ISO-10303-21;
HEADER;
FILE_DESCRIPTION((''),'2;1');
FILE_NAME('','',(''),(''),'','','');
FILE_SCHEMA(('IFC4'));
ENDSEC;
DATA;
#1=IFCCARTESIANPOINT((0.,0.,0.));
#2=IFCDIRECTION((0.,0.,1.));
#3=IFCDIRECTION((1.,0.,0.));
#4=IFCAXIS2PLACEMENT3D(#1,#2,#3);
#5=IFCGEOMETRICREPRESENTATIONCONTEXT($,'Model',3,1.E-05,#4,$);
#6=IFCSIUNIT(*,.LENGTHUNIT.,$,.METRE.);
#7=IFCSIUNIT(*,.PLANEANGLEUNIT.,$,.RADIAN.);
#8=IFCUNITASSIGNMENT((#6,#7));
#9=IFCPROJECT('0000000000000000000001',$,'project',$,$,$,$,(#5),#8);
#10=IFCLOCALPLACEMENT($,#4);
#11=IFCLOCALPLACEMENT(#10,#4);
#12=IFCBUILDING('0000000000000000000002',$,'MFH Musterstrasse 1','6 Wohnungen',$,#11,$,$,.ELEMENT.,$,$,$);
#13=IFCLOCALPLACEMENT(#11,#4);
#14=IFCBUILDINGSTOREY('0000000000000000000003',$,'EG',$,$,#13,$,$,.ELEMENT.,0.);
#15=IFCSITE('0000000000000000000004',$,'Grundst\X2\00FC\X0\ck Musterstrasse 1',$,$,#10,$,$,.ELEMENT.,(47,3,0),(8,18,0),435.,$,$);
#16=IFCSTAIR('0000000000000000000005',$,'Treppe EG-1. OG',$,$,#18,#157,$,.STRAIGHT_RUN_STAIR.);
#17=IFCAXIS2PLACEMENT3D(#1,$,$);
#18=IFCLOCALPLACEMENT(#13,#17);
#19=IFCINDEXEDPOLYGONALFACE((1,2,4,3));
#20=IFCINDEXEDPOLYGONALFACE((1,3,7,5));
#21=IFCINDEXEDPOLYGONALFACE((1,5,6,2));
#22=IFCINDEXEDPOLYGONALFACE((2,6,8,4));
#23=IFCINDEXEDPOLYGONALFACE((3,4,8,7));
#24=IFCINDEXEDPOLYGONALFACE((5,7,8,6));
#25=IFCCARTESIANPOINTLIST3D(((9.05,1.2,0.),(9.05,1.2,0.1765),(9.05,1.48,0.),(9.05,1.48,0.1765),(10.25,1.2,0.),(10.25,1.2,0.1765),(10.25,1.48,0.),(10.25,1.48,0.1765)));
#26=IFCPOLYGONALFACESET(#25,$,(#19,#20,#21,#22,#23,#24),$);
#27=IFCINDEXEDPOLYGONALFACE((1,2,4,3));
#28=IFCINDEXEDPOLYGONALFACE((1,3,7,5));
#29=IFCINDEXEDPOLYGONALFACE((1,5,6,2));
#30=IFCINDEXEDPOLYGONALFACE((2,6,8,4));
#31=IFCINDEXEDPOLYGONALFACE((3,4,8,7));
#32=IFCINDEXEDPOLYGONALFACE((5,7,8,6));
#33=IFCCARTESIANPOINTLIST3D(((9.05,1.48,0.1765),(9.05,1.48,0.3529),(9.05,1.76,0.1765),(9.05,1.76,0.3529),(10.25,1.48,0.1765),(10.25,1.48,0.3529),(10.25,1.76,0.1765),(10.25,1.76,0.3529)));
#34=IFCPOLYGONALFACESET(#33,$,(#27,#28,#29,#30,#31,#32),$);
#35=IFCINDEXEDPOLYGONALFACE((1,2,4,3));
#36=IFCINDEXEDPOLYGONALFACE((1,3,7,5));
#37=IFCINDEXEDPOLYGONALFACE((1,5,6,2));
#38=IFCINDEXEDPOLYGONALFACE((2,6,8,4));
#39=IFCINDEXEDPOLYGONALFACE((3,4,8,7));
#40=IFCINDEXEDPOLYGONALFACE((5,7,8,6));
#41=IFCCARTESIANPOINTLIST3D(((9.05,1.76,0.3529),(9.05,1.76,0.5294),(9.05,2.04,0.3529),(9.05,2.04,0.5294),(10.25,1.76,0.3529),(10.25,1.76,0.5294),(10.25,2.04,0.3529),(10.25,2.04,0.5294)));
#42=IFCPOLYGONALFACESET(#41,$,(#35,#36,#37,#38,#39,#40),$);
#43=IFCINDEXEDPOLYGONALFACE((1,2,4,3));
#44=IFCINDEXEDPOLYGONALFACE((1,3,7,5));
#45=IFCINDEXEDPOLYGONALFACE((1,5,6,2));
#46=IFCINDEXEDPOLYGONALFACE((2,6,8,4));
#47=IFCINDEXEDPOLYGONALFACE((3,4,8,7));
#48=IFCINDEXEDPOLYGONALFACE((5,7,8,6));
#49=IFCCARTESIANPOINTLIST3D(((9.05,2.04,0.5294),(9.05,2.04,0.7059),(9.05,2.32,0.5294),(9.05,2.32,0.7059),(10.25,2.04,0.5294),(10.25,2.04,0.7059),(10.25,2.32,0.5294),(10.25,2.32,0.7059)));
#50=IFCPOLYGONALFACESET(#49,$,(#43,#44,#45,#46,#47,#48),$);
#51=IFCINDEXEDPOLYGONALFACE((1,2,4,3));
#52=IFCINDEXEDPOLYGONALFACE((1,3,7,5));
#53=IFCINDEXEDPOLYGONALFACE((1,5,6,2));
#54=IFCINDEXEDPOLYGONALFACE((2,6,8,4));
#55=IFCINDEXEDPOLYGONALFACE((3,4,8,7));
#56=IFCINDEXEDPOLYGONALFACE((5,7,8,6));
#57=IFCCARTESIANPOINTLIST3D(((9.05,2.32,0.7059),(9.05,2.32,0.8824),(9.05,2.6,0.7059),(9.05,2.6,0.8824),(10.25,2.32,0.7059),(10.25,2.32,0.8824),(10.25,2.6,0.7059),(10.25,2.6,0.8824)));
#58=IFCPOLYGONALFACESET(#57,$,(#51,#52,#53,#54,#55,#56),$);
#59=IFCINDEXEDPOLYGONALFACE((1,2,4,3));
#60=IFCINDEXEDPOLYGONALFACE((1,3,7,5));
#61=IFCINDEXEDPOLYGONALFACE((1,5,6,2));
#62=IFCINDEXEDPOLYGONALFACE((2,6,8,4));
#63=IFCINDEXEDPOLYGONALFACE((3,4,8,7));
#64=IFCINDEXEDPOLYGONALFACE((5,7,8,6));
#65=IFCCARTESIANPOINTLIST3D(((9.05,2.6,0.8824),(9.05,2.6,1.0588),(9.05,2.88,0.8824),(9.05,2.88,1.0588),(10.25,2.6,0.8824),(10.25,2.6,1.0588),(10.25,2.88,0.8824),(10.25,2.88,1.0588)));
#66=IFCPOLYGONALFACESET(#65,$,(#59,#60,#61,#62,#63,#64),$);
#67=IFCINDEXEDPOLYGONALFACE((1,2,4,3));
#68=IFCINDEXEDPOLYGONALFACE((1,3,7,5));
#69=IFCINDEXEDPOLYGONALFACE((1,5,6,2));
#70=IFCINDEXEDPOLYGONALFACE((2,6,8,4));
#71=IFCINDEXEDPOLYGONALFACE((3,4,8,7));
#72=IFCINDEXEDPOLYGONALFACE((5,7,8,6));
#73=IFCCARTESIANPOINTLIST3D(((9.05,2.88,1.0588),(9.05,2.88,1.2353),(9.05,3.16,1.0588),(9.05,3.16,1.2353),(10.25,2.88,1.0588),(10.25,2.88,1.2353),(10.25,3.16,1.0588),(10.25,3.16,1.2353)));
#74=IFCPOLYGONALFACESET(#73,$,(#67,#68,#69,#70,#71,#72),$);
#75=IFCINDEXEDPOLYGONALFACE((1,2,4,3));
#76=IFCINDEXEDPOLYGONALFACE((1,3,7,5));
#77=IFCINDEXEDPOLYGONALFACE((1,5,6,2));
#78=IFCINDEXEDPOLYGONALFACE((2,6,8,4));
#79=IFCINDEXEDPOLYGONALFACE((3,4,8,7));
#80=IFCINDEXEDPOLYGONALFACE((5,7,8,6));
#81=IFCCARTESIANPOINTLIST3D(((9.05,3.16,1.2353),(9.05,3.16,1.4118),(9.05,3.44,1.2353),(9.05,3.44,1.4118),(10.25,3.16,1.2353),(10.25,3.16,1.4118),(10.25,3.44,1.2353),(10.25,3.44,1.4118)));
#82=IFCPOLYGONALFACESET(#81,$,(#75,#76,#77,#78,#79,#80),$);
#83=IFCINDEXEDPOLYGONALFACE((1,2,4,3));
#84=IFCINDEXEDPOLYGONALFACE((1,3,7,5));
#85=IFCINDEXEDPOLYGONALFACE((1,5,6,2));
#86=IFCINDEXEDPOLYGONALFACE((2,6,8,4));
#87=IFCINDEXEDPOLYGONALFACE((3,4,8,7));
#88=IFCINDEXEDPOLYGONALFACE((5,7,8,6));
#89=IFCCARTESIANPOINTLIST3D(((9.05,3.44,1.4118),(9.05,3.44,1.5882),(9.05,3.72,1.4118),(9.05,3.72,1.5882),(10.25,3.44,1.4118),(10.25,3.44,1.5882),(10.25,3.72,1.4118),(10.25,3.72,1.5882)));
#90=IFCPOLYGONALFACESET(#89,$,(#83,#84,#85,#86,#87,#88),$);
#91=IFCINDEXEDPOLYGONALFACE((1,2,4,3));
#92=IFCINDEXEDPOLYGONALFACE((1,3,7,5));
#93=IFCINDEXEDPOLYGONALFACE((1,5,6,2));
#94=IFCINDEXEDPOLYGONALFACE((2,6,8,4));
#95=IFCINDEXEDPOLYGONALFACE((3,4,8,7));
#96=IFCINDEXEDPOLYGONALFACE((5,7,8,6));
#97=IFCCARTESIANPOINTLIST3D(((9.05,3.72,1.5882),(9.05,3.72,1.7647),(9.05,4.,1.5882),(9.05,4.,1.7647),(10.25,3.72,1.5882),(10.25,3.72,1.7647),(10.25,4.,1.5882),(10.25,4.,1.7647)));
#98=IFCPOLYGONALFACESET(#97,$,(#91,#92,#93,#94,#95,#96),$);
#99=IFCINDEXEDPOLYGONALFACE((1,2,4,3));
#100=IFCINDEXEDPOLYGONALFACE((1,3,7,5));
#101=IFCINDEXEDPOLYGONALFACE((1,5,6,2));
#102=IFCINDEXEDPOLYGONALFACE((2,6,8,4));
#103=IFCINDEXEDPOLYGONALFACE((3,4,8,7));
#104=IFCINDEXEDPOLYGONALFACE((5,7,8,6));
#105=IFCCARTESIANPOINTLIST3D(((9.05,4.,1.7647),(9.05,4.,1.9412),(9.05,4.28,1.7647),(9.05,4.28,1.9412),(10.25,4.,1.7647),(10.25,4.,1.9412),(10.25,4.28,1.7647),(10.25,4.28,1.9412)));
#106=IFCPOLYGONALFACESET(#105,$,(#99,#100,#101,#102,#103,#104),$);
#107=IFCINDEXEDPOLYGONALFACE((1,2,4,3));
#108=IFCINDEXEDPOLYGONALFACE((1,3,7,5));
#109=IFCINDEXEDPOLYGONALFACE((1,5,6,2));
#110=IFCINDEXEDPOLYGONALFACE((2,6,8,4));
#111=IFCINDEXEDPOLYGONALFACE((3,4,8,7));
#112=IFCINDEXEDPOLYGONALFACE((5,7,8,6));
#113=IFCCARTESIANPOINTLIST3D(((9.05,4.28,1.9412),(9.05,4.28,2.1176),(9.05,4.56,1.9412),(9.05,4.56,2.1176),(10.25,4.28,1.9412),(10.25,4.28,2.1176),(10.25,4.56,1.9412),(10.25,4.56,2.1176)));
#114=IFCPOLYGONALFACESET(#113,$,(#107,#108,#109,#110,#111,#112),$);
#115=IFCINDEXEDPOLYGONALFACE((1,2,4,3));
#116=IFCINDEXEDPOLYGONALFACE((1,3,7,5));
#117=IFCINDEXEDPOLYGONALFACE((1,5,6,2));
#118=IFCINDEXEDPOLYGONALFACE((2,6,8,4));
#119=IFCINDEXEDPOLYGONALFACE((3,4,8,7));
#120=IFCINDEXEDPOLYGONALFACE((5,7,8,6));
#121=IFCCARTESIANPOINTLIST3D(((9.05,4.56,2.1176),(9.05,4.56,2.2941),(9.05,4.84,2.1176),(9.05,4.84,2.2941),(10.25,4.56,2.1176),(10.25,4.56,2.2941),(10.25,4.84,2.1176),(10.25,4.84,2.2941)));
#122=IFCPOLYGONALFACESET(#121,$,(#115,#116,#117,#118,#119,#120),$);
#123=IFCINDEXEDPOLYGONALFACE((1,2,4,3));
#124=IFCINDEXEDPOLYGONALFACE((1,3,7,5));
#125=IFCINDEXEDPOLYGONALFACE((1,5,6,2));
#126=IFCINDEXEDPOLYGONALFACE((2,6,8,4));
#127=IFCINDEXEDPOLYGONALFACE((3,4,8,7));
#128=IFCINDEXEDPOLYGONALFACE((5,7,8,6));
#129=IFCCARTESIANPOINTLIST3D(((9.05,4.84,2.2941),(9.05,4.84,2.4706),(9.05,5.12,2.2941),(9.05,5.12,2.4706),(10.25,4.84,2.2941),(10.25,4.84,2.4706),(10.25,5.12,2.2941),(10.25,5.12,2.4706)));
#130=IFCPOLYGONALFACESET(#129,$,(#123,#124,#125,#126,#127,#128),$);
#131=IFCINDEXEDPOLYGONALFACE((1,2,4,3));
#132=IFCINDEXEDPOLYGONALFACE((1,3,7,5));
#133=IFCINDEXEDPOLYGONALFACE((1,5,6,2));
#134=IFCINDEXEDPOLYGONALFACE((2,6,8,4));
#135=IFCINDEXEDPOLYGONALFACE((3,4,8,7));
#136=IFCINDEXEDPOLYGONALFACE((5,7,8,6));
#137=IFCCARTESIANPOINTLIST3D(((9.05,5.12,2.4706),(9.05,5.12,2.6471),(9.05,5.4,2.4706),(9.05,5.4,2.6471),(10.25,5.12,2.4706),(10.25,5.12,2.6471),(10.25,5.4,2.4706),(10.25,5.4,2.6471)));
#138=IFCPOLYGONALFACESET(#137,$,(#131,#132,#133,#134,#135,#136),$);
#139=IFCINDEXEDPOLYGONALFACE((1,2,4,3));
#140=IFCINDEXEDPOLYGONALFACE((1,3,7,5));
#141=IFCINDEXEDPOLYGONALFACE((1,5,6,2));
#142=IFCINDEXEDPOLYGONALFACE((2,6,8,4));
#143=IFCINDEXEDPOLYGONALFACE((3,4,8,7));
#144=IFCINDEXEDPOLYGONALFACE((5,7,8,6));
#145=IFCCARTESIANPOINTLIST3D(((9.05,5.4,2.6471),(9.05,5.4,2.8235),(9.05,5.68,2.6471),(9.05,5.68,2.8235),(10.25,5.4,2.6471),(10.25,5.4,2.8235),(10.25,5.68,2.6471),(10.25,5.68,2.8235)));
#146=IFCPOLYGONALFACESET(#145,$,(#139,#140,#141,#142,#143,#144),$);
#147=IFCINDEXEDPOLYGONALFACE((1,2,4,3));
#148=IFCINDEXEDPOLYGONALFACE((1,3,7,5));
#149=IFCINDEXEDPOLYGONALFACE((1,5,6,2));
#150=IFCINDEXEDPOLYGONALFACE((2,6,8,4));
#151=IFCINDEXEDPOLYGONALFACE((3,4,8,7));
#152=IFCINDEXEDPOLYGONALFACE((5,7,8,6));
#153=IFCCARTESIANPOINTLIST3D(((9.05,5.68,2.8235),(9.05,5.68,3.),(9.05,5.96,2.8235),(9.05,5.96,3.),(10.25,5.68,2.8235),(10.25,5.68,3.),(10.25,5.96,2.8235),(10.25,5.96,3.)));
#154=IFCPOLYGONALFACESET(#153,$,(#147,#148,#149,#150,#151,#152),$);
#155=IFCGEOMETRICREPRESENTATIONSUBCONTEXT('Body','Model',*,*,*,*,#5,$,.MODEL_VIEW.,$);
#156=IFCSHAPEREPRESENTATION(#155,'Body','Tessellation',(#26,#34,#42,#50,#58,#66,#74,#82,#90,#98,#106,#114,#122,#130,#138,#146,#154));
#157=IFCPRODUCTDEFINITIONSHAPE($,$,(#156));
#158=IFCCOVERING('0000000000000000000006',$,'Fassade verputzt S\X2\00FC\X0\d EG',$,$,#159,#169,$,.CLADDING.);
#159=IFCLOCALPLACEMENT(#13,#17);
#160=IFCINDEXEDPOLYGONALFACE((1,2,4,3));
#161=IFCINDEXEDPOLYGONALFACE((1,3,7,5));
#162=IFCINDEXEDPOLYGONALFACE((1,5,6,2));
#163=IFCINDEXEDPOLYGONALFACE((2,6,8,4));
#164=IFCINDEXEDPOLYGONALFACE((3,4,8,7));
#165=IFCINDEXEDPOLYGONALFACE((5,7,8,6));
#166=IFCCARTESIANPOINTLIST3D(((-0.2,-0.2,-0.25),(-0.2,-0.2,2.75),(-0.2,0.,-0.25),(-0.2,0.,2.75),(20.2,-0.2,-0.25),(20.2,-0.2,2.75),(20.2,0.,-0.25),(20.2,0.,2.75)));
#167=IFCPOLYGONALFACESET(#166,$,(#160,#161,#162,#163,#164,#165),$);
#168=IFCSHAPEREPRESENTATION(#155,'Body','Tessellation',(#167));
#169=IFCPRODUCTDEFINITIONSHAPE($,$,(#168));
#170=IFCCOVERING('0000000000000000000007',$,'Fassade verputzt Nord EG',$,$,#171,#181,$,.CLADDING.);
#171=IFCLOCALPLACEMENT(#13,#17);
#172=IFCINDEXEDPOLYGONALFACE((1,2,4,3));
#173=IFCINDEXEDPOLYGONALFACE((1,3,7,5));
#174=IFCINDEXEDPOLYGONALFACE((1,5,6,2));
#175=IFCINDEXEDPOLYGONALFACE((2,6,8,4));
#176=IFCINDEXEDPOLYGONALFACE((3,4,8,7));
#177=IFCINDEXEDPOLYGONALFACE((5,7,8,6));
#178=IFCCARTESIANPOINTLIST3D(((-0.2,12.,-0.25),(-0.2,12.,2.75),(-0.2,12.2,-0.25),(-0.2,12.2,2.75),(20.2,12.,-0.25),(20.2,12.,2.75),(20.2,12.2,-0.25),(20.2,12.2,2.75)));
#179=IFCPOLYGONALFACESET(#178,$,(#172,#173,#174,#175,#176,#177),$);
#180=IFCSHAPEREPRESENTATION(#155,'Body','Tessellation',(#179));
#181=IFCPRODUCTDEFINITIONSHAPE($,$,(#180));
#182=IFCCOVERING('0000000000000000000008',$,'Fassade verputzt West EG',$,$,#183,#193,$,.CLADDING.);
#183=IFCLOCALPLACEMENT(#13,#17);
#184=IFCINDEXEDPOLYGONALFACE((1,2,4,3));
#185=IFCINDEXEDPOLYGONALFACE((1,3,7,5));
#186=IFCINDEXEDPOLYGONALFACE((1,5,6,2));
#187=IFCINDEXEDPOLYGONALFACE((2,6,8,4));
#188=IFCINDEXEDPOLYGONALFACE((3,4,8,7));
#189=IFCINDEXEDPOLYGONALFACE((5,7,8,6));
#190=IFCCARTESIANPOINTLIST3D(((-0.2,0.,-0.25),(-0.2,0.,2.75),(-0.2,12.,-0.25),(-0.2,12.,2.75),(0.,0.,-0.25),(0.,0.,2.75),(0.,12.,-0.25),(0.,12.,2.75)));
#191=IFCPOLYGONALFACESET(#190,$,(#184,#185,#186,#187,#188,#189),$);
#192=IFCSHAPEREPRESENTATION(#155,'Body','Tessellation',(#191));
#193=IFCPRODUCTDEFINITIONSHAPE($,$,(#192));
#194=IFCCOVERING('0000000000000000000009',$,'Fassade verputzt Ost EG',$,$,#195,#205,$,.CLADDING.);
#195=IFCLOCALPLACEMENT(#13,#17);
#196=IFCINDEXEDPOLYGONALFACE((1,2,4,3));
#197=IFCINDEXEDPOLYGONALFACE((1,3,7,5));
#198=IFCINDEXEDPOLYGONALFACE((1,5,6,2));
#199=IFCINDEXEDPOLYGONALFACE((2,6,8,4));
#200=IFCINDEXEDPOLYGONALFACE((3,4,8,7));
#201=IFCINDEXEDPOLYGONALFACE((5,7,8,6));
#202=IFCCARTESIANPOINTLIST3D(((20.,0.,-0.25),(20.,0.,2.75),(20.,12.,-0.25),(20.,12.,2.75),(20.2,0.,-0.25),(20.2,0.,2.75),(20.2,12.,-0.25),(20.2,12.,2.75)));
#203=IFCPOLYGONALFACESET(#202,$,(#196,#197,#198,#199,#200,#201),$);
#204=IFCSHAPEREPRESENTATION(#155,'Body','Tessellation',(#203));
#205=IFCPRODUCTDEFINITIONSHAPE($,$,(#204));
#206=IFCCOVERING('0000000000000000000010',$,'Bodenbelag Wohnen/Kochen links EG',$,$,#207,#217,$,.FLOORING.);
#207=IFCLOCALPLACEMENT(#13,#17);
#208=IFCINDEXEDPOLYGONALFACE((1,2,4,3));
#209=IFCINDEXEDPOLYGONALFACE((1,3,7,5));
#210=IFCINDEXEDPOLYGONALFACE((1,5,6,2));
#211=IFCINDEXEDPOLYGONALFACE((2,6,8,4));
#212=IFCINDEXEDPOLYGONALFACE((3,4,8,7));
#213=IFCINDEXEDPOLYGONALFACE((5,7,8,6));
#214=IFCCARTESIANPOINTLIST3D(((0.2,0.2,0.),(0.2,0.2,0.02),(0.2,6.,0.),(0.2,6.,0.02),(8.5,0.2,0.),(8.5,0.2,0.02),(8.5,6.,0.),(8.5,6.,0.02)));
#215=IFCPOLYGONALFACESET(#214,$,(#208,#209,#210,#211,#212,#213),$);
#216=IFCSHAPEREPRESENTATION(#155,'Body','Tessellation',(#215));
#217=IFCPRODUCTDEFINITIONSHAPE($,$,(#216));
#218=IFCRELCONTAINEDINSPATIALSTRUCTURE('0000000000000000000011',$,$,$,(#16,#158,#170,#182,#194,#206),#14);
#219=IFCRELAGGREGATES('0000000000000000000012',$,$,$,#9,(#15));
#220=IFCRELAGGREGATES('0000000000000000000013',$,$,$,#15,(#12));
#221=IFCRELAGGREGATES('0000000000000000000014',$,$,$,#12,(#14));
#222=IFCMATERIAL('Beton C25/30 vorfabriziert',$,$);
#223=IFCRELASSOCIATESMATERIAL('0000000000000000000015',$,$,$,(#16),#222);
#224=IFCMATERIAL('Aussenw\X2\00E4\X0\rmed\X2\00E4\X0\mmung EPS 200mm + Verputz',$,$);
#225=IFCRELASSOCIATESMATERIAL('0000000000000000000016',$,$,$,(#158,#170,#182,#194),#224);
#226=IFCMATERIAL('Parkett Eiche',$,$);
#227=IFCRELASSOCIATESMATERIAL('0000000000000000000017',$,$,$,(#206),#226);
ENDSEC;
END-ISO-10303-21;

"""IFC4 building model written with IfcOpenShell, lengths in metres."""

from ifc_helpers import new_model, si_unit, frame, frame_2d, origin_with_axes, place, context, subcontext, project, spatial, rectangle, extrude, material, element, save


model = new_model("IFC4")

# Units and contexts
model_context = context("Model", 3, precision=1e-05, world=origin_with_axes())
body_context = subcontext(model_context, "Body", "Model", "MODEL_VIEW")
ifc_project = project(units=[si_unit("LENGTHUNIT", "METRE"), si_unit("PLANEANGLEUNIT", "RADIAN")], contexts=[model_context])

# Site, building, storey
site_placement = place(None, origin_with_axes())
site = spatial("IfcSite", under=ifc_project, at=site_placement, Name="Grundstück Musterstrasse 1", CompositionType="ELEMENT", RefLatitude=(47, 3, 0), RefLongitude=(8, 18, 0), RefElevation=435.0)
building_placement = place(site_placement, origin_with_axes())
building = spatial("IfcBuilding", under=site, at=building_placement, Name="MFH Musterstrasse 1", Description="6 Wohnungen", CompositionType="ELEMENT")
storey_placement = place(building_placement, origin_with_axes())
storey = spatial("IfcBuildingStorey", under=building, at=storey_placement, Name="EG", CompositionType="ELEMENT", Elevation=0.0)

# Stair
ifc_material_1 = material(Name="Beton C25/30 vorfabriziert")
stair_placement = place(storey_placement, origin_with_axes())
element("IfcStair", 1, at=stair_placement, inside=storey, material=ifc_material_1, Name="Treppe EG-1. OG", PredefinedType="STRAIGHT_RUN_STAIR", context=body_context, shape_type="SweptSolid", body=[
    extrude(rectangle(XDim=1.2, YDim=0.28, at=frame_2d((0.6, 0.14), x_axis=(1.0, 0.0))), frame((9.05, 1.2, 0.0), z_axis=(0.0, 0.0, 1.0), x_axis=(1.0, 0.0, 0.0)), (0.0, 0.0, 1.0), 0.1765),
    extrude(rectangle(XDim=1.2, YDim=0.28, at=frame_2d((0.6, 0.14), x_axis=(1.0, 0.0))), frame((9.05, 1.48, 0.1765), z_axis=(0.0, 0.0, 1.0), x_axis=(1.0, 0.0, 0.0)), (0.0, 0.0, 1.0), 0.1765),
    extrude(rectangle(XDim=1.2, YDim=0.28, at=frame_2d((0.6, 0.14), x_axis=(1.0, 0.0))), frame((9.05, 1.76, 0.3529), z_axis=(0.0, 0.0, 1.0), x_axis=(1.0, 0.0, 0.0)), (0.0, 0.0, 1.0), 0.1765),
    extrude(rectangle(XDim=1.2, YDim=0.28, at=frame_2d((0.6, 0.14), x_axis=(1.0, 0.0))), frame((9.05, 2.04, 0.5294), z_axis=(0.0, 0.0, 1.0), x_axis=(1.0, 0.0, 0.0)), (0.0, 0.0, 1.0), 0.1765),
    extrude(rectangle(XDim=1.2, YDim=0.28, at=frame_2d((0.6, 0.14), x_axis=(1.0, 0.0))), frame((9.05, 2.32, 0.7059), z_axis=(0.0, 0.0, 1.0), x_axis=(1.0, 0.0, 0.0)), (0.0, 0.0, 1.0), 0.1765),
    extrude(rectangle(XDim=1.2, YDim=0.28, at=frame_2d((0.6, 0.14), x_axis=(1.0, 0.0))), frame((9.05, 2.6, 0.8824), z_axis=(0.0, 0.0, 1.0), x_axis=(1.0, 0.0, 0.0)), (0.0, 0.0, 1.0), 0.1765),
    extrude(rectangle(XDim=1.2, YDim=0.28, at=frame_2d((0.6, 0.14), x_axis=(1.0, 0.0))), frame((9.05, 2.88, 1.0588), z_axis=(0.0, 0.0, 1.0), x_axis=(1.0, 0.0, 0.0)), (0.0, 0.0, 1.0), 0.1765),
    extrude(rectangle(XDim=1.2, YDim=0.28, at=frame_2d((0.6, 0.14), x_axis=(1.0, 0.0))), frame((9.05, 3.16, 1.2353), z_axis=(0.0, 0.0, 1.0), x_axis=(1.0, 0.0, 0.0)), (0.0, 0.0, 1.0), 0.1765),
    extrude(rectangle(XDim=1.2, YDim=0.28, at=frame_2d((0.6, 0.14), x_axis=(1.0, 0.0))), frame((9.05, 3.44, 1.4118), z_axis=(0.0, 0.0, 1.0), x_axis=(1.0, 0.0, 0.0)), (0.0, 0.0, 1.0), 0.1765),
    extrude(rectangle(XDim=1.2, YDim=0.28, at=frame_2d((0.6, 0.14), x_axis=(1.0, 0.0))), frame((9.05, 3.72, 1.5882), z_axis=(0.0, 0.0, 1.0), x_axis=(1.0, 0.0, 0.0)), (0.0, 0.0, 1.0), 0.1765),
    extrude(rectangle(XDim=1.2, YDim=0.28, at=frame_2d((0.6, 0.14), x_axis=(1.0, 0.0))), frame((9.05, 4.0, 1.7647), z_axis=(0.0, 0.0, 1.0), x_axis=(1.0, 0.0, 0.0)), (0.0, 0.0, 1.0), 0.1765),
    extrude(rectangle(XDim=1.2, YDim=0.28, at=frame_2d((0.6, 0.14), x_axis=(1.0, 0.0))), frame((9.05, 4.28, 1.9412), z_axis=(0.0, 0.0, 1.0), x_axis=(1.0, 0.0, 0.0)), (0.0, 0.0, 1.0), 0.1765),
    extrude(rectangle(XDim=1.2, YDim=0.28, at=frame_2d((0.6, 0.14), x_axis=(1.0, 0.0))), frame((9.05, 4.56, 2.1176), z_axis=(0.0, 0.0, 1.0), x_axis=(1.0, 0.0, 0.0)), (0.0, 0.0, 1.0), 0.1765),
    extrude(rectangle(XDim=1.2, YDim=0.28, at=frame_2d((0.6, 0.14), x_axis=(1.0, 0.0))), frame((9.05, 4.84, 2.2941), z_axis=(0.0, 0.0, 1.0), x_axis=(1.0, 0.0, 0.0)), (0.0, 0.0, 1.0), 0.1765),
    extrude(rectangle(XDim=1.2, YDim=0.28, at=frame_2d((0.6, 0.14), x_axis=(1.0, 0.0))), frame((9.05, 5.12, 2.4706), z_axis=(0.0, 0.0, 1.0), x_axis=(1.0, 0.0, 0.0)), (0.0, 0.0, 1.0), 0.1765),
    extrude(rectangle(XDim=1.2, YDim=0.28, at=frame_2d((0.6, 0.14), x_axis=(1.0, 0.0))), frame((9.05, 5.4, 2.6471), z_axis=(0.0, 0.0, 1.0), x_axis=(1.0, 0.0, 0.0)), (0.0, 0.0, 1.0), 0.1765),
    extrude(rectangle(XDim=1.2, YDim=0.28, at=frame_2d((0.6, 0.14), x_axis=(1.0, 0.0))), frame((9.05, 5.68, 2.8235), z_axis=(0.0, 0.0, 1.0), x_axis=(1.0, 0.0, 0.0)), (0.0, 0.0, 1.0), 0.1765),
])

# Coverings
ifc_material_2 = material(Name="Aussenwärmedämmung EPS 200mm + Verputz")
covering_1_placement = place(storey_placement, origin_with_axes())
element("IfcCovering", 2, at=covering_1_placement, inside=storey, material=ifc_material_2, Name="Fassade verputzt Süd EG", PredefinedType="CLADDING", context=body_context, shape_type="SweptSolid", body=[
    extrude(rectangle(XDim=20.4, YDim=0.2, at=frame_2d((10.2, 0.1), x_axis=(1.0, 0.0))), frame((-0.2, -0.2, -0.25), z_axis=(0.0, 0.0, 1.0), x_axis=(1.0, 0.0, 0.0)), (0.0, 0.0, 1.0), 3.0),
])
covering_2_placement = place(storey_placement, origin_with_axes())
element("IfcCovering", 3, at=covering_2_placement, inside=storey, material=ifc_material_2, Name="Fassade verputzt Nord EG", PredefinedType="CLADDING", context=body_context, shape_type="SweptSolid", body=[
    extrude(rectangle(XDim=20.4, YDim=0.2, at=frame_2d((10.2, 0.1), x_axis=(1.0, 0.0))), frame((-0.2, 12.0, -0.25), z_axis=(0.0, 0.0, 1.0), x_axis=(1.0, 0.0, 0.0)), (0.0, 0.0, 1.0), 3.0),
])
covering_3_placement = place(storey_placement, origin_with_axes())
element("IfcCovering", 4, at=covering_3_placement, inside=storey, material=ifc_material_2, Name="Fassade verputzt West EG", PredefinedType="CLADDING", context=body_context, shape_type="SweptSolid", body=[
    extrude(rectangle(XDim=0.2, YDim=12.0, at=frame_2d((0.1, 6.0), x_axis=(1.0, 0.0))), frame((-0.2, 0.0, -0.25), z_axis=(0.0, 0.0, 1.0), x_axis=(1.0, 0.0, 0.0)), (0.0, 0.0, 1.0), 3.0),
])
covering_4_placement = place(storey_placement, origin_with_axes())
element("IfcCovering", 5, at=covering_4_placement, inside=storey, material=ifc_material_2, Name="Fassade verputzt Ost EG", PredefinedType="CLADDING", context=body_context, shape_type="SweptSolid", body=[
    extrude(rectangle(XDim=0.2, YDim=12.0, at=frame_2d((0.1, 6.0), x_axis=(1.0, 0.0))), frame((20.0, 0.0, -0.25), z_axis=(0.0, 0.0, 1.0), x_axis=(1.0, 0.0, 0.0)), (0.0, 0.0, 1.0), 3.0),
])
ifc_material_3 = material(Name="Parkett Eiche")
covering_5_placement = place(storey_placement, origin_with_axes())
element("IfcCovering", 6, at=covering_5_placement, inside=storey, material=ifc_material_3, Name="Bodenbelag Wohnen/Kochen links EG", PredefinedType="FLOORING", context=body_context, shape_type="SweptSolid", body=[
    extrude(rectangle(XDim=8.3, YDim=5.8, at=frame_2d((4.15, 2.9), x_axis=(1.0, 0.0))), frame((0.2, 0.2, 0.0), z_axis=(0.0, 0.0, 1.0), x_axis=(1.0, 0.0, 0.0)), (0.0, 0.0, 1.0), 0.02),
])

save(model, "model.ifc")
